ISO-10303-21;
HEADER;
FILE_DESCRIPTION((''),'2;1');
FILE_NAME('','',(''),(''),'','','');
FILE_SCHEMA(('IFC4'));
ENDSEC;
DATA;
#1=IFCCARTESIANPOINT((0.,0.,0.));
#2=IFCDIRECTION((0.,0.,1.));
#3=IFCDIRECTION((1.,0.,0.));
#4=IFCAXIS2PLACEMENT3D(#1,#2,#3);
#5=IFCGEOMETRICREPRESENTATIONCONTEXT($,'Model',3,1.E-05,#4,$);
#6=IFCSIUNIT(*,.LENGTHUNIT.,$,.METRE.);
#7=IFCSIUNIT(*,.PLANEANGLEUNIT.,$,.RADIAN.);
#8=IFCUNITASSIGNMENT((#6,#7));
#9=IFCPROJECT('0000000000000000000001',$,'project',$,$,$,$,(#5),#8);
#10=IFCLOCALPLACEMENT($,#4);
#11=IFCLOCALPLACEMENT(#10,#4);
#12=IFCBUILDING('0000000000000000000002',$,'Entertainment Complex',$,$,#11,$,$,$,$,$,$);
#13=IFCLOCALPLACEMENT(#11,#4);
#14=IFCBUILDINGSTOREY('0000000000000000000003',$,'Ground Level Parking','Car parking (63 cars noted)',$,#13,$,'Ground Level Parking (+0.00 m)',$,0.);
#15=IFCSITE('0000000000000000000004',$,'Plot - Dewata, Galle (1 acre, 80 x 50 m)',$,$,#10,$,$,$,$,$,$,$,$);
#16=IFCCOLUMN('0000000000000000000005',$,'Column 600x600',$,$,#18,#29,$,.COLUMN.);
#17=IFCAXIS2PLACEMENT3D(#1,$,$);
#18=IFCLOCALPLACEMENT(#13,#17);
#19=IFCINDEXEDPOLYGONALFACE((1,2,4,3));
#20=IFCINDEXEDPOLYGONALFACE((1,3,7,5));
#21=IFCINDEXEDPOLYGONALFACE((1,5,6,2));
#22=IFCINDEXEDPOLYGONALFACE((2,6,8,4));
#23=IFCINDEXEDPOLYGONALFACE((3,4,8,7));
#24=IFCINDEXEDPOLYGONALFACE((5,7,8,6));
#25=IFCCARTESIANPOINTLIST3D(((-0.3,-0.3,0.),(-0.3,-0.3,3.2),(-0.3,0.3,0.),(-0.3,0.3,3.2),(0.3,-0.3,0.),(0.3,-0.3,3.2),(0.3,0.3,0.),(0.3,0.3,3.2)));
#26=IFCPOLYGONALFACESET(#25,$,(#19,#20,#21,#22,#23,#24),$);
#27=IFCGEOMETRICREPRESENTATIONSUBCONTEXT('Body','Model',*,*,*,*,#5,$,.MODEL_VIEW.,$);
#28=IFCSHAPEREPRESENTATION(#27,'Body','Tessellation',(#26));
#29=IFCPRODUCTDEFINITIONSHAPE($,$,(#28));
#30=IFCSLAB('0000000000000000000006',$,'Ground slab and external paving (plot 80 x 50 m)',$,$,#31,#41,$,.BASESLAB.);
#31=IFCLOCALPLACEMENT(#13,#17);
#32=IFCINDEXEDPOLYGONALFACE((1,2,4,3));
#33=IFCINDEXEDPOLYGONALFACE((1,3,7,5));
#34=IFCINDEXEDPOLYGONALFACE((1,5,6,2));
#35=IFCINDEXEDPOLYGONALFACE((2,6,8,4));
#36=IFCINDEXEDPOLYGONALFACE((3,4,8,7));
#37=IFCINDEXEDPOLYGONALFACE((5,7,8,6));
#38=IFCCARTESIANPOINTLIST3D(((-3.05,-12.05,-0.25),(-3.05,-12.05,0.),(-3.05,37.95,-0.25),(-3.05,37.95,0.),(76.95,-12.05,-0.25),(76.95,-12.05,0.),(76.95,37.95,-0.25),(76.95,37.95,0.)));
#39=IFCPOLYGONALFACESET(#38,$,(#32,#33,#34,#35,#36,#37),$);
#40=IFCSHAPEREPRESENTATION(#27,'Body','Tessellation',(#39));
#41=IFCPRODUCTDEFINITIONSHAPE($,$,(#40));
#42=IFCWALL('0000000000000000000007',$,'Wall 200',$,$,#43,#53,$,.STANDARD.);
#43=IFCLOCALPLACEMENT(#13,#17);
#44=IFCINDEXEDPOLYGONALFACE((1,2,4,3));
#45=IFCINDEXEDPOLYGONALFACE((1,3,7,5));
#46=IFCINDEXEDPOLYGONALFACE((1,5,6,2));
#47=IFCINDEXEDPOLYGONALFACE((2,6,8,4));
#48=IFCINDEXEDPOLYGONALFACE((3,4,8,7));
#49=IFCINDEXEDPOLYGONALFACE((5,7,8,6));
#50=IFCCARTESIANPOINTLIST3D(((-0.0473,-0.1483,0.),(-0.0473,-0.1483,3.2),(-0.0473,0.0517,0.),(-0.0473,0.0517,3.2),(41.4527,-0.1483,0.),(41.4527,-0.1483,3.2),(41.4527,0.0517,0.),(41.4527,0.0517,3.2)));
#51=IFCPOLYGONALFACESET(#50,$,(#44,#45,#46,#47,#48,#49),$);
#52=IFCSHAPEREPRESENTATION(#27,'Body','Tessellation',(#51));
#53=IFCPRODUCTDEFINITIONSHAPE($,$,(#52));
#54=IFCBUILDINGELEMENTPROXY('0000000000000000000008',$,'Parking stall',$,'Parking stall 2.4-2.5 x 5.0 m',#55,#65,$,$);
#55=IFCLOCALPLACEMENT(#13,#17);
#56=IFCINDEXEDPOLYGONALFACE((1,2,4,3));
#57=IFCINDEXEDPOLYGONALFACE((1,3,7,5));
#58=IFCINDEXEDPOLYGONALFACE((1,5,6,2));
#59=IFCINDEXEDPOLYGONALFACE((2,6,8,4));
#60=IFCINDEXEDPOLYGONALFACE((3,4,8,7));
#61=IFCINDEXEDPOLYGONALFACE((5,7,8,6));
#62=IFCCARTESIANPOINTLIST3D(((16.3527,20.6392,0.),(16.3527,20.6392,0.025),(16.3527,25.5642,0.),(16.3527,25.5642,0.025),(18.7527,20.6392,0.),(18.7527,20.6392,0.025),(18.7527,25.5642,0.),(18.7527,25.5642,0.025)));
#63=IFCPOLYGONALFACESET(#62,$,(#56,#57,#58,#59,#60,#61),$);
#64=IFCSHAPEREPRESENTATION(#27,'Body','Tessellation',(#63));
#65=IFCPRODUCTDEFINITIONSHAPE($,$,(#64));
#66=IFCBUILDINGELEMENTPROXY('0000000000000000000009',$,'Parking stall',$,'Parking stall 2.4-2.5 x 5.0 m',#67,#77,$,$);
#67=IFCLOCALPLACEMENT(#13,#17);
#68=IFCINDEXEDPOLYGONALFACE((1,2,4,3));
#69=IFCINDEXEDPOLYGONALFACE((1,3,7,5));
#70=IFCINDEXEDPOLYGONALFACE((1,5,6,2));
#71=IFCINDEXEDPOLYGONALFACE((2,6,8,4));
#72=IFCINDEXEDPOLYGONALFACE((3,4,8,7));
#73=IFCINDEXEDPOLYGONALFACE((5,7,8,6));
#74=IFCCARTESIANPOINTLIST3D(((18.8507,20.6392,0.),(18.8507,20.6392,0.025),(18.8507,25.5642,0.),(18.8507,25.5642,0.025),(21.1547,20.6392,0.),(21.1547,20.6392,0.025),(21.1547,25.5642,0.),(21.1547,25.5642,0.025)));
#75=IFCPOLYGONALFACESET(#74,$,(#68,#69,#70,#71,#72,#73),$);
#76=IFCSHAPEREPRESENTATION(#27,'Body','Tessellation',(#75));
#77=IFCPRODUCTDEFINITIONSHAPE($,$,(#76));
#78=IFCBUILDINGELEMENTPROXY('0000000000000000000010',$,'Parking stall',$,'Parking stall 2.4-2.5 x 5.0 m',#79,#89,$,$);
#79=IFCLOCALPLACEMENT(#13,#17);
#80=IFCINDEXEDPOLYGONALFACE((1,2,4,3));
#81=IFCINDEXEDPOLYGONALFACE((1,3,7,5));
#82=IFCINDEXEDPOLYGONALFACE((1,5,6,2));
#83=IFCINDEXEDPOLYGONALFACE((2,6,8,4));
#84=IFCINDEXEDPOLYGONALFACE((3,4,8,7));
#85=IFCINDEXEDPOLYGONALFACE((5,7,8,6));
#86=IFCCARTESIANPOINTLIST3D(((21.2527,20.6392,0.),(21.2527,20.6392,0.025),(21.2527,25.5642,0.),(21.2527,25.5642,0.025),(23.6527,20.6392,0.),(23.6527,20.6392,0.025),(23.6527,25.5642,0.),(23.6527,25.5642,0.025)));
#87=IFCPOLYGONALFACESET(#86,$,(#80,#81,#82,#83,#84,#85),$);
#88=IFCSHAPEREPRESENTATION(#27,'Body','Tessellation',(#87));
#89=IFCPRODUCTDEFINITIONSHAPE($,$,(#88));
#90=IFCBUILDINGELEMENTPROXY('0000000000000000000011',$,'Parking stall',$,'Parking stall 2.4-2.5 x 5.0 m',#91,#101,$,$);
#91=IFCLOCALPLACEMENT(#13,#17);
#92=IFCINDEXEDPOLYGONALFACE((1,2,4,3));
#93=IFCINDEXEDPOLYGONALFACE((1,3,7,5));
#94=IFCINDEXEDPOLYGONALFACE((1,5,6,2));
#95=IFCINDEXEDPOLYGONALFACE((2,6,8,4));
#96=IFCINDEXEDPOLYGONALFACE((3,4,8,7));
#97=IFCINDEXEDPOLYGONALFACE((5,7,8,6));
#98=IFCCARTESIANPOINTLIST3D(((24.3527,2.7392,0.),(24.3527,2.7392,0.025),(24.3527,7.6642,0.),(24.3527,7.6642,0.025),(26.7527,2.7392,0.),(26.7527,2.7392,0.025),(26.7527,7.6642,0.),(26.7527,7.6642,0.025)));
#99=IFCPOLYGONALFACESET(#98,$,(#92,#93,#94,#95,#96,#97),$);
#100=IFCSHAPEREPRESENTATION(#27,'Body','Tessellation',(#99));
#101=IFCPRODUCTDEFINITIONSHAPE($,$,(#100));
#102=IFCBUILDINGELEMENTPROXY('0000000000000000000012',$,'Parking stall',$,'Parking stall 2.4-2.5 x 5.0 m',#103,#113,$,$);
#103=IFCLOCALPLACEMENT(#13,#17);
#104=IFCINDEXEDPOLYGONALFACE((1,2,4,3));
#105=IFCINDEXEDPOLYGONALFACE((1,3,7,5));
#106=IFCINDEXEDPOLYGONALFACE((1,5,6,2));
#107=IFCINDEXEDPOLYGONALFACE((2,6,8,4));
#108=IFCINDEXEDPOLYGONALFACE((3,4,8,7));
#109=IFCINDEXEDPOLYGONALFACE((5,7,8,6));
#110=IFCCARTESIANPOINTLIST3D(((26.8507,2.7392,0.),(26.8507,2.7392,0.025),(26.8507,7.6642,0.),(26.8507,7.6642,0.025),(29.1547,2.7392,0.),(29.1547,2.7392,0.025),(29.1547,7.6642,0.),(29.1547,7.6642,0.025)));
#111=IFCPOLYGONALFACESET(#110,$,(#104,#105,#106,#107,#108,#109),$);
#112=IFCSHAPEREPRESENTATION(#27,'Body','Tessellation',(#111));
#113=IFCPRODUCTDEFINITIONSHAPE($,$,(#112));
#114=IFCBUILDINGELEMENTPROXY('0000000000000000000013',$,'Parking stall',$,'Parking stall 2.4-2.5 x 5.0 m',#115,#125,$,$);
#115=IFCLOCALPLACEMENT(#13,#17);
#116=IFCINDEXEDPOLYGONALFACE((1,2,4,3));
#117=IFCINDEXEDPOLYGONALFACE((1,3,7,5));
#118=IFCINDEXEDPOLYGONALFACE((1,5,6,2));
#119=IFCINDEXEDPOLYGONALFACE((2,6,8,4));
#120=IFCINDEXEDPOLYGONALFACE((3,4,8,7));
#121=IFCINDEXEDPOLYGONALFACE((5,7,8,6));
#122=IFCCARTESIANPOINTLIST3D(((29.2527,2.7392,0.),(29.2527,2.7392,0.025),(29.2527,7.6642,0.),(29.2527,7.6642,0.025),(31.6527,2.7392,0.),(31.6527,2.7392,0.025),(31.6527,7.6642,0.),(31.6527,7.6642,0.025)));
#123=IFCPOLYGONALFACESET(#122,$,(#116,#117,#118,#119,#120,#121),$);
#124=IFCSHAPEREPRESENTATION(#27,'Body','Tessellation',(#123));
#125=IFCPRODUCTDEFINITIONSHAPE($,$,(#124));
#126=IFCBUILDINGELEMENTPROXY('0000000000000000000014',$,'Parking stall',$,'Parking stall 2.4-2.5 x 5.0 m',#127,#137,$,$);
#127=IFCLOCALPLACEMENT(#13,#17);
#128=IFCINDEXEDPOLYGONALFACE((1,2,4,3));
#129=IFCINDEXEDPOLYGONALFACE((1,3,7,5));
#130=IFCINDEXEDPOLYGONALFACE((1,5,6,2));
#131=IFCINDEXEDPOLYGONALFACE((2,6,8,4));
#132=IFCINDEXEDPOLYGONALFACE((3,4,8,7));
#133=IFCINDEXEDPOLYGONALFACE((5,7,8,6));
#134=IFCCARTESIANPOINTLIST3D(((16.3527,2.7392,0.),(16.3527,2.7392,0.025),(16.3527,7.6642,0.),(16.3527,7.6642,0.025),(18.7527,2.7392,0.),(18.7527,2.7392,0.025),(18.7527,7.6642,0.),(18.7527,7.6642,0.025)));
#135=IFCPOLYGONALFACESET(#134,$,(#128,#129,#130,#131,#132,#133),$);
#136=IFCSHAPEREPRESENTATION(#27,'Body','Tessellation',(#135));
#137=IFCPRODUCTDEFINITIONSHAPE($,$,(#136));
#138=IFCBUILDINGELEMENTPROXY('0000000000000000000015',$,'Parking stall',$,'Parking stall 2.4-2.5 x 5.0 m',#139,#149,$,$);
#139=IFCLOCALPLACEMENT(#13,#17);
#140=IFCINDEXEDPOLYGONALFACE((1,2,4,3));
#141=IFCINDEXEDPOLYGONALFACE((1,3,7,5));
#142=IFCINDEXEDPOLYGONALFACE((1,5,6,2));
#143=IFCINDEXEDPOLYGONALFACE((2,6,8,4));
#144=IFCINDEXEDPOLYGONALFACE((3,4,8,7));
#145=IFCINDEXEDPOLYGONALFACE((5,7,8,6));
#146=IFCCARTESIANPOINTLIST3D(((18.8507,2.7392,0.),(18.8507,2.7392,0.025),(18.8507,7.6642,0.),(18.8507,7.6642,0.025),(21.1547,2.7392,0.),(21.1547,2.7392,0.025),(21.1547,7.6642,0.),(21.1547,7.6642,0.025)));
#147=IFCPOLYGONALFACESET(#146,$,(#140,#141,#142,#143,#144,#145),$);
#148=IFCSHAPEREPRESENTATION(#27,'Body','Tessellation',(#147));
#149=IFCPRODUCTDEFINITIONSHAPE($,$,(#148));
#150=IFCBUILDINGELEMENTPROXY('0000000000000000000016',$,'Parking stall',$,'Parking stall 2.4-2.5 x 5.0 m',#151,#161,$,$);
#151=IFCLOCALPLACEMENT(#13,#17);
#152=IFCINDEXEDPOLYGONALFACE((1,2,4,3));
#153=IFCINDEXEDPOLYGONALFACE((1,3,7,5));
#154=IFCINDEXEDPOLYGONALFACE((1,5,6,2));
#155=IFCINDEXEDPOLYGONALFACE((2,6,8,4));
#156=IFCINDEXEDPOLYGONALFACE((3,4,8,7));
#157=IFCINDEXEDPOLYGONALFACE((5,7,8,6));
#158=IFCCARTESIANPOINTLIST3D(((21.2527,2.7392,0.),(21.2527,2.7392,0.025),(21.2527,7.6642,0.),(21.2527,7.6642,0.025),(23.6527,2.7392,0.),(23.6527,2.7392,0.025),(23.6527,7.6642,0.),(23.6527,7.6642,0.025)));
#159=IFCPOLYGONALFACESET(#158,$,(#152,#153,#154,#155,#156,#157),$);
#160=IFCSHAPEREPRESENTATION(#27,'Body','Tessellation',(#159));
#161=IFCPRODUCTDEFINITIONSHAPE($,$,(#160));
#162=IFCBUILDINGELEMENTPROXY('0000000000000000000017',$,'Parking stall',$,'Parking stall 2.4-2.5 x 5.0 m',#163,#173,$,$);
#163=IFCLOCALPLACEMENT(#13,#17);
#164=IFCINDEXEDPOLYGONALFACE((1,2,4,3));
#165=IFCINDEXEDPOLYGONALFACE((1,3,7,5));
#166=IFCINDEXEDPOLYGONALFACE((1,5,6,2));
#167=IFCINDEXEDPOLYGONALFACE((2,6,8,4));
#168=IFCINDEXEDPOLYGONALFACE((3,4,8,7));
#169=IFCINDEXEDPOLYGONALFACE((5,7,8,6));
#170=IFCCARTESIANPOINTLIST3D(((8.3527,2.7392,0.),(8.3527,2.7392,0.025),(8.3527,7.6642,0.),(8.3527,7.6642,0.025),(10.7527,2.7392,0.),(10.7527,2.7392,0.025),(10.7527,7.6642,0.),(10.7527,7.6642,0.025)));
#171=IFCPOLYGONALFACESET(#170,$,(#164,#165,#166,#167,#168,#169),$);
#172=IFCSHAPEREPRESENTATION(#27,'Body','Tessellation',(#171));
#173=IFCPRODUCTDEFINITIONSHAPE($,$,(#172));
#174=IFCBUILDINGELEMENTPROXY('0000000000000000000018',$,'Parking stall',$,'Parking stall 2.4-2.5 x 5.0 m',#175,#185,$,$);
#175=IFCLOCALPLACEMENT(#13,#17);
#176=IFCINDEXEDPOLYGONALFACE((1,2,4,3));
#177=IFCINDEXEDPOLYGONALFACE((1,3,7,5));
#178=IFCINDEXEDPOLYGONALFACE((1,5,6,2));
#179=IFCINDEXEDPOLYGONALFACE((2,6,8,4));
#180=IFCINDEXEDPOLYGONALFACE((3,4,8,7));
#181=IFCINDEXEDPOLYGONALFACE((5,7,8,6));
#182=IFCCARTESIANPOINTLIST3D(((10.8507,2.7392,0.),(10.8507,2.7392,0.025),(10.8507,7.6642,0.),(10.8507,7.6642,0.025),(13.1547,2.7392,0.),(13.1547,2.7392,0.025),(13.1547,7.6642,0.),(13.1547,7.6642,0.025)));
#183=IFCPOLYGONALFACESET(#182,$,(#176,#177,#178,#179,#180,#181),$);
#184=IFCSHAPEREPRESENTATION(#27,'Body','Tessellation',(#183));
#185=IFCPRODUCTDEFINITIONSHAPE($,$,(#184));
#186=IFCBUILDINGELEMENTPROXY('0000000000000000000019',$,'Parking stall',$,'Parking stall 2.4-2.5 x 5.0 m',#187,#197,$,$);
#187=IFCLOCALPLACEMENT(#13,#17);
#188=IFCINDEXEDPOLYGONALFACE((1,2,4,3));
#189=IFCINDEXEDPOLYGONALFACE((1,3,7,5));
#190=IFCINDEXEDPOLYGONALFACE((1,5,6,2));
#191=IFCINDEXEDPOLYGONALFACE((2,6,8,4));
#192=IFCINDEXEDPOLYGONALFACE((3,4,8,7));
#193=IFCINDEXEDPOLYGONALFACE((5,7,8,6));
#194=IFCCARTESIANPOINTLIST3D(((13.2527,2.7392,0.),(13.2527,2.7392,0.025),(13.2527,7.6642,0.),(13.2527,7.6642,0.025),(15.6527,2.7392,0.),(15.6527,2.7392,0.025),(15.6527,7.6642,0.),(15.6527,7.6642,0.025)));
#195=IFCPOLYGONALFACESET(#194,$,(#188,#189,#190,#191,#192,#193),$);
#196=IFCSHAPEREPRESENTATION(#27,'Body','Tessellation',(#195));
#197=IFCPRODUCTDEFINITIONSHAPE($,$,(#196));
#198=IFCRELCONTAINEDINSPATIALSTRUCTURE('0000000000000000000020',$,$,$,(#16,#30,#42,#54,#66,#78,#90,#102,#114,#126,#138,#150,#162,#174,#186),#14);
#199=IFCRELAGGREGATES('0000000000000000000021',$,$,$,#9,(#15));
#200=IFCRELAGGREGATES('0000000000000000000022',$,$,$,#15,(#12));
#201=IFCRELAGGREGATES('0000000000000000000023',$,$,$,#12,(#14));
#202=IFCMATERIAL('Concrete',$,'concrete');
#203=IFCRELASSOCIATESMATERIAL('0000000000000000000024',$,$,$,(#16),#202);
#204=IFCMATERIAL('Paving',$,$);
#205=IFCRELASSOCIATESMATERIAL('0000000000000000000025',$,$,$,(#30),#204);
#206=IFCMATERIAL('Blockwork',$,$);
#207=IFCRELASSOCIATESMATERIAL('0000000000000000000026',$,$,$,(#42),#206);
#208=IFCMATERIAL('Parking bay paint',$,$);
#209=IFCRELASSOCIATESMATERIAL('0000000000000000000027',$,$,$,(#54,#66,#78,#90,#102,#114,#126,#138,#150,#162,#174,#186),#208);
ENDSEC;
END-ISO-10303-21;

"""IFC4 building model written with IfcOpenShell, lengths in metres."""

from ifc_helpers import new_model, si_unit, frame, origin_with_axes, place, context, subcontext, project, spatial, polyline, outline, extrude, material, element, save


model = new_model("IFC4")

# Units and contexts
model_context = context("Model", 3, precision=1e-05, world=origin_with_axes())
body_context = subcontext(model_context, "Body", "Model", "MODEL_VIEW")
ifc_project = project(units=[si_unit("LENGTHUNIT", "METRE"), si_unit("PLANEANGLEUNIT", "RADIAN")], contexts=[model_context])

# Site, building, storey
site_placement = place(None, origin_with_axes())
site = spatial("IfcSite", under=ifc_project, at=site_placement, Name="Plot - Dewata, Galle (1 acre, 80 x 50 m)")
building_placement = place(site_placement, origin_with_axes())
building = spatial("IfcBuilding", under=site, at=building_placement, Name="Entertainment Complex")
storey_placement = place(building_placement, origin_with_axes())
storey = spatial("IfcBuildingStorey", under=building, at=storey_placement, Name="Ground Level Parking", Description="Car parking (63 cars noted)", LongName="Ground Level Parking (+0.00 m)", Elevation=0.0)

# Column
ifc_material_1 = material(Name="Concrete", Category="concrete")
column_placement = place(storey_placement, origin_with_axes())
element("IfcColumn", 1, at=column_placement, inside=storey, material=ifc_material_1, Name="Column 600x600", PredefinedType="COLUMN", context=body_context, shape_type="SweptSolid", body=[
    extrude(outline(polyline([(-0.3, -0.3), (0.3, -0.3), (0.3, 0.3), (-0.3, 0.3), (-0.3, -0.3)])), origin_with_axes(), (0.0, 0.0, 1.0), 3.2),
])

# Slab
ifc_material_2 = material(Name="Paving")
slab_placement = place(storey_placement, origin_with_axes())
element("IfcSlab", 2, at=slab_placement, inside=storey, material=ifc_material_2, Name="Ground slab and external paving (plot 80 x 50 m)", PredefinedType="BASESLAB", context=body_context, shape_type="SweptSolid", body=[
    extrude(outline(polyline([(76.95, -12.05), (76.95, 37.95), (-3.05, 37.95), (-3.05, -12.05), (76.95, -12.05)])), frame((0.0, 0.0, -0.25), z_axis=(0.0, 0.0, 1.0), x_axis=(1.0, 0.0, 0.0)), (0.0, 0.0, 1.0), 0.25),
])

# Wall
ifc_material_3 = material(Name="Blockwork")
wall_placement = place(storey_placement, frame((-0.0473, -0.0483, 0.0), z_axis=(0.0, 0.0, 1.0), x_axis=(1.0, 0.0, 0.0)))
element("IfcWall", 3, at=wall_placement, inside=storey, material=ifc_material_3, Name="Wall 200", PredefinedType="STANDARD", context=body_context, shape_type="SweptSolid", body=[
    extrude(outline(polyline([(0.0, -0.1), (41.5, -0.1), (41.5, 0.1), (0.0, 0.1), (0.0, -0.1)])), origin_with_axes(), (0.0, 0.0, 1.0), 3.2),
])

# Building element proxies
ifc_material_4 = material(Name="Parking bay paint")
proxy_1_placement = place(storey_placement, origin_with_axes())
element("IfcBuildingElementProxy", 4, at=proxy_1_placement, inside=storey, material=ifc_material_4, Name="Parking stall", ObjectType="Parking stall 2.4-2.5 x 5.0 m", context=body_context, shape_type="SweptSolid", body=[
    extrude(outline(polyline([(16.3527, 20.6392), (18.7527, 20.6392), (18.7527, 25.5642), (16.3527, 25.5642), (16.3527, 20.6392)])), origin_with_axes(), (0.0, 0.0, 1.0), 0.025),
])
proxy_2_placement = place(storey_placement, origin_with_axes())
element("IfcBuildingElementProxy", 5, at=proxy_2_placement, inside=storey, material=ifc_material_4, Name="Parking stall", ObjectType="Parking stall 2.4-2.5 x 5.0 m", context=body_context, shape_type="SweptSolid", body=[
    extrude(outline(polyline([(18.8507, 20.6392), (21.1547, 20.6392), (21.1547, 25.5642), (18.8507, 25.5642), (18.8507, 20.6392)])), origin_with_axes(), (0.0, 0.0, 1.0), 0.025),
])
proxy_3_placement = place(storey_placement, origin_with_axes())
element("IfcBuildingElementProxy", 6, at=proxy_3_placement, inside=storey, material=ifc_material_4, Name="Parking stall", ObjectType="Parking stall 2.4-2.5 x 5.0 m", context=body_context, shape_type="SweptSolid", body=[
    extrude(outline(polyline([(21.2527, 20.6392), (23.6527, 20.6392), (23.6527, 25.5642), (21.2527, 25.5642), (21.2527, 20.6392)])), origin_with_axes(), (0.0, 0.0, 1.0), 0.025),
])
proxy_4_placement = place(storey_placement, origin_with_axes())
element("IfcBuildingElementProxy", 7, at=proxy_4_placement, inside=storey, material=ifc_material_4, Name="Parking stall", ObjectType="Parking stall 2.4-2.5 x 5.0 m", context=body_context, shape_type="SweptSolid", body=[
    extrude(outline(polyline([(24.3527, 2.7392), (26.7527, 2.7392), (26.7527, 7.6642), (24.3527, 7.6642), (24.3527, 2.7392)])), origin_with_axes(), (0.0, 0.0, 1.0), 0.025),
])
proxy_5_placement = place(storey_placement, origin_with_axes())
element("IfcBuildingElementProxy", 8, at=proxy_5_placement, inside=storey, material=ifc_material_4, Name="Parking stall", ObjectType="Parking stall 2.4-2.5 x 5.0 m", context=body_context, shape_type="SweptSolid", body=[
    extrude(outline(polyline([(26.8507, 2.7392), (29.1547, 2.7392), (29.1547, 7.6642), (26.8507, 7.6642), (26.8507, 2.7392)])), origin_with_axes(), (0.0, 0.0, 1.0), 0.025),
])
proxy_6_placement = place(storey_placement, origin_with_axes())
element("IfcBuildingElementProxy", 9, at=proxy_6_placement, inside=storey, material=ifc_material_4, Name="Parking stall", ObjectType="Parking stall 2.4-2.5 x 5.0 m", context=body_context, shape_type="SweptSolid", body=[
    extrude(outline(polyline([(29.2527, 2.7392), (31.6527, 2.7392), (31.6527, 7.6642), (29.2527, 7.6642), (29.2527, 2.7392)])), origin_with_axes(), (0.0, 0.0, 1.0), 0.025),
])
proxy_7_placement = place(storey_placement, origin_with_axes())
element("IfcBuildingElementProxy", 10, at=proxy_7_placement, inside=storey, material=ifc_material_4, Name="Parking stall", ObjectType="Parking stall 2.4-2.5 x 5.0 m", context=body_context, shape_type="SweptSolid", body=[
    extrude(outline(polyline([(16.3527, 2.7392), (18.7527, 2.7392), (18.7527, 7.6642), (16.3527, 7.6642), (16.3527, 2.7392)])), origin_with_axes(), (0.0, 0.0, 1.0), 0.025),
])
proxy_8_placement = place(storey_placement, origin_with_axes())
element("IfcBuildingElementProxy", 11, at=proxy_8_placement, inside=storey, material=ifc_material_4, Name="Parking stall", ObjectType="Parking stall 2.4-2.5 x 5.0 m", context=body_context, shape_type="SweptSolid", body=[
    extrude(outline(polyline([(18.8507, 2.7392), (21.1547, 2.7392), (21.1547, 7.6642), (18.8507, 7.6642), (18.8507, 2.7392)])), origin_with_axes(), (0.0, 0.0, 1.0), 0.025),
])
proxy_9_placement = place(storey_placement, origin_with_axes())
element("IfcBuildingElementProxy", 12, at=proxy_9_placement, inside=storey, material=ifc_material_4, Name="Parking stall", ObjectType="Parking stall 2.4-2.5 x 5.0 m", context=body_context, shape_type="SweptSolid", body=[
    extrude(outline(polyline([(21.2527, 2.7392), (23.6527, 2.7392), (23.6527, 7.6642), (21.2527, 7.6642), (21.2527, 2.7392)])), origin_with_axes(), (0.0, 0.0, 1.0), 0.025),
])
proxy_10_placement = place(storey_placement, origin_with_axes())
element("IfcBuildingElementProxy", 13, at=proxy_10_placement, inside=storey, material=ifc_material_4, Name="Parking stall", ObjectType="Parking stall 2.4-2.5 x 5.0 m", context=body_context, shape_type="SweptSolid", body=[
    extrude(outline(polyline([(8.3527, 2.7392), (10.7527, 2.7392), (10.7527, 7.6642), (8.3527, 7.6642), (8.3527, 2.7392)])), origin_with_axes(), (0.0, 0.0, 1.0), 0.025),
])
proxy_11_placement = place(storey_placement, origin_with_axes())
element("IfcBuildingElementProxy", 14, at=proxy_11_placement, inside=storey, material=ifc_material_4, Name="Parking stall", ObjectType="Parking stall 2.4-2.5 x 5.0 m", context=body_context, shape_type="SweptSolid", body=[
    extrude(outline(polyline([(10.8507, 2.7392), (13.1547, 2.7392), (13.1547, 7.6642), (10.8507, 7.6642), (10.8507, 2.7392)])), origin_with_axes(), (0.0, 0.0, 1.0), 0.025),
])
proxy_12_placement = place(storey_placement, origin_with_axes())
element("IfcBuildingElementProxy", 15, at=proxy_12_placement, inside=storey, material=ifc_material_4, Name="Parking stall", ObjectType="Parking stall 2.4-2.5 x 5.0 m", context=body_context, shape_type="SweptSolid", body=[
    extrude(outline(polyline([(13.2527, 2.7392), (15.6527, 2.7392), (15.6527, 7.6642), (13.2527, 7.6642), (13.2527, 2.7392)])), origin_with_axes(), (0.0, 0.0, 1.0), 0.025),
])

save(model, "model.ifc")
